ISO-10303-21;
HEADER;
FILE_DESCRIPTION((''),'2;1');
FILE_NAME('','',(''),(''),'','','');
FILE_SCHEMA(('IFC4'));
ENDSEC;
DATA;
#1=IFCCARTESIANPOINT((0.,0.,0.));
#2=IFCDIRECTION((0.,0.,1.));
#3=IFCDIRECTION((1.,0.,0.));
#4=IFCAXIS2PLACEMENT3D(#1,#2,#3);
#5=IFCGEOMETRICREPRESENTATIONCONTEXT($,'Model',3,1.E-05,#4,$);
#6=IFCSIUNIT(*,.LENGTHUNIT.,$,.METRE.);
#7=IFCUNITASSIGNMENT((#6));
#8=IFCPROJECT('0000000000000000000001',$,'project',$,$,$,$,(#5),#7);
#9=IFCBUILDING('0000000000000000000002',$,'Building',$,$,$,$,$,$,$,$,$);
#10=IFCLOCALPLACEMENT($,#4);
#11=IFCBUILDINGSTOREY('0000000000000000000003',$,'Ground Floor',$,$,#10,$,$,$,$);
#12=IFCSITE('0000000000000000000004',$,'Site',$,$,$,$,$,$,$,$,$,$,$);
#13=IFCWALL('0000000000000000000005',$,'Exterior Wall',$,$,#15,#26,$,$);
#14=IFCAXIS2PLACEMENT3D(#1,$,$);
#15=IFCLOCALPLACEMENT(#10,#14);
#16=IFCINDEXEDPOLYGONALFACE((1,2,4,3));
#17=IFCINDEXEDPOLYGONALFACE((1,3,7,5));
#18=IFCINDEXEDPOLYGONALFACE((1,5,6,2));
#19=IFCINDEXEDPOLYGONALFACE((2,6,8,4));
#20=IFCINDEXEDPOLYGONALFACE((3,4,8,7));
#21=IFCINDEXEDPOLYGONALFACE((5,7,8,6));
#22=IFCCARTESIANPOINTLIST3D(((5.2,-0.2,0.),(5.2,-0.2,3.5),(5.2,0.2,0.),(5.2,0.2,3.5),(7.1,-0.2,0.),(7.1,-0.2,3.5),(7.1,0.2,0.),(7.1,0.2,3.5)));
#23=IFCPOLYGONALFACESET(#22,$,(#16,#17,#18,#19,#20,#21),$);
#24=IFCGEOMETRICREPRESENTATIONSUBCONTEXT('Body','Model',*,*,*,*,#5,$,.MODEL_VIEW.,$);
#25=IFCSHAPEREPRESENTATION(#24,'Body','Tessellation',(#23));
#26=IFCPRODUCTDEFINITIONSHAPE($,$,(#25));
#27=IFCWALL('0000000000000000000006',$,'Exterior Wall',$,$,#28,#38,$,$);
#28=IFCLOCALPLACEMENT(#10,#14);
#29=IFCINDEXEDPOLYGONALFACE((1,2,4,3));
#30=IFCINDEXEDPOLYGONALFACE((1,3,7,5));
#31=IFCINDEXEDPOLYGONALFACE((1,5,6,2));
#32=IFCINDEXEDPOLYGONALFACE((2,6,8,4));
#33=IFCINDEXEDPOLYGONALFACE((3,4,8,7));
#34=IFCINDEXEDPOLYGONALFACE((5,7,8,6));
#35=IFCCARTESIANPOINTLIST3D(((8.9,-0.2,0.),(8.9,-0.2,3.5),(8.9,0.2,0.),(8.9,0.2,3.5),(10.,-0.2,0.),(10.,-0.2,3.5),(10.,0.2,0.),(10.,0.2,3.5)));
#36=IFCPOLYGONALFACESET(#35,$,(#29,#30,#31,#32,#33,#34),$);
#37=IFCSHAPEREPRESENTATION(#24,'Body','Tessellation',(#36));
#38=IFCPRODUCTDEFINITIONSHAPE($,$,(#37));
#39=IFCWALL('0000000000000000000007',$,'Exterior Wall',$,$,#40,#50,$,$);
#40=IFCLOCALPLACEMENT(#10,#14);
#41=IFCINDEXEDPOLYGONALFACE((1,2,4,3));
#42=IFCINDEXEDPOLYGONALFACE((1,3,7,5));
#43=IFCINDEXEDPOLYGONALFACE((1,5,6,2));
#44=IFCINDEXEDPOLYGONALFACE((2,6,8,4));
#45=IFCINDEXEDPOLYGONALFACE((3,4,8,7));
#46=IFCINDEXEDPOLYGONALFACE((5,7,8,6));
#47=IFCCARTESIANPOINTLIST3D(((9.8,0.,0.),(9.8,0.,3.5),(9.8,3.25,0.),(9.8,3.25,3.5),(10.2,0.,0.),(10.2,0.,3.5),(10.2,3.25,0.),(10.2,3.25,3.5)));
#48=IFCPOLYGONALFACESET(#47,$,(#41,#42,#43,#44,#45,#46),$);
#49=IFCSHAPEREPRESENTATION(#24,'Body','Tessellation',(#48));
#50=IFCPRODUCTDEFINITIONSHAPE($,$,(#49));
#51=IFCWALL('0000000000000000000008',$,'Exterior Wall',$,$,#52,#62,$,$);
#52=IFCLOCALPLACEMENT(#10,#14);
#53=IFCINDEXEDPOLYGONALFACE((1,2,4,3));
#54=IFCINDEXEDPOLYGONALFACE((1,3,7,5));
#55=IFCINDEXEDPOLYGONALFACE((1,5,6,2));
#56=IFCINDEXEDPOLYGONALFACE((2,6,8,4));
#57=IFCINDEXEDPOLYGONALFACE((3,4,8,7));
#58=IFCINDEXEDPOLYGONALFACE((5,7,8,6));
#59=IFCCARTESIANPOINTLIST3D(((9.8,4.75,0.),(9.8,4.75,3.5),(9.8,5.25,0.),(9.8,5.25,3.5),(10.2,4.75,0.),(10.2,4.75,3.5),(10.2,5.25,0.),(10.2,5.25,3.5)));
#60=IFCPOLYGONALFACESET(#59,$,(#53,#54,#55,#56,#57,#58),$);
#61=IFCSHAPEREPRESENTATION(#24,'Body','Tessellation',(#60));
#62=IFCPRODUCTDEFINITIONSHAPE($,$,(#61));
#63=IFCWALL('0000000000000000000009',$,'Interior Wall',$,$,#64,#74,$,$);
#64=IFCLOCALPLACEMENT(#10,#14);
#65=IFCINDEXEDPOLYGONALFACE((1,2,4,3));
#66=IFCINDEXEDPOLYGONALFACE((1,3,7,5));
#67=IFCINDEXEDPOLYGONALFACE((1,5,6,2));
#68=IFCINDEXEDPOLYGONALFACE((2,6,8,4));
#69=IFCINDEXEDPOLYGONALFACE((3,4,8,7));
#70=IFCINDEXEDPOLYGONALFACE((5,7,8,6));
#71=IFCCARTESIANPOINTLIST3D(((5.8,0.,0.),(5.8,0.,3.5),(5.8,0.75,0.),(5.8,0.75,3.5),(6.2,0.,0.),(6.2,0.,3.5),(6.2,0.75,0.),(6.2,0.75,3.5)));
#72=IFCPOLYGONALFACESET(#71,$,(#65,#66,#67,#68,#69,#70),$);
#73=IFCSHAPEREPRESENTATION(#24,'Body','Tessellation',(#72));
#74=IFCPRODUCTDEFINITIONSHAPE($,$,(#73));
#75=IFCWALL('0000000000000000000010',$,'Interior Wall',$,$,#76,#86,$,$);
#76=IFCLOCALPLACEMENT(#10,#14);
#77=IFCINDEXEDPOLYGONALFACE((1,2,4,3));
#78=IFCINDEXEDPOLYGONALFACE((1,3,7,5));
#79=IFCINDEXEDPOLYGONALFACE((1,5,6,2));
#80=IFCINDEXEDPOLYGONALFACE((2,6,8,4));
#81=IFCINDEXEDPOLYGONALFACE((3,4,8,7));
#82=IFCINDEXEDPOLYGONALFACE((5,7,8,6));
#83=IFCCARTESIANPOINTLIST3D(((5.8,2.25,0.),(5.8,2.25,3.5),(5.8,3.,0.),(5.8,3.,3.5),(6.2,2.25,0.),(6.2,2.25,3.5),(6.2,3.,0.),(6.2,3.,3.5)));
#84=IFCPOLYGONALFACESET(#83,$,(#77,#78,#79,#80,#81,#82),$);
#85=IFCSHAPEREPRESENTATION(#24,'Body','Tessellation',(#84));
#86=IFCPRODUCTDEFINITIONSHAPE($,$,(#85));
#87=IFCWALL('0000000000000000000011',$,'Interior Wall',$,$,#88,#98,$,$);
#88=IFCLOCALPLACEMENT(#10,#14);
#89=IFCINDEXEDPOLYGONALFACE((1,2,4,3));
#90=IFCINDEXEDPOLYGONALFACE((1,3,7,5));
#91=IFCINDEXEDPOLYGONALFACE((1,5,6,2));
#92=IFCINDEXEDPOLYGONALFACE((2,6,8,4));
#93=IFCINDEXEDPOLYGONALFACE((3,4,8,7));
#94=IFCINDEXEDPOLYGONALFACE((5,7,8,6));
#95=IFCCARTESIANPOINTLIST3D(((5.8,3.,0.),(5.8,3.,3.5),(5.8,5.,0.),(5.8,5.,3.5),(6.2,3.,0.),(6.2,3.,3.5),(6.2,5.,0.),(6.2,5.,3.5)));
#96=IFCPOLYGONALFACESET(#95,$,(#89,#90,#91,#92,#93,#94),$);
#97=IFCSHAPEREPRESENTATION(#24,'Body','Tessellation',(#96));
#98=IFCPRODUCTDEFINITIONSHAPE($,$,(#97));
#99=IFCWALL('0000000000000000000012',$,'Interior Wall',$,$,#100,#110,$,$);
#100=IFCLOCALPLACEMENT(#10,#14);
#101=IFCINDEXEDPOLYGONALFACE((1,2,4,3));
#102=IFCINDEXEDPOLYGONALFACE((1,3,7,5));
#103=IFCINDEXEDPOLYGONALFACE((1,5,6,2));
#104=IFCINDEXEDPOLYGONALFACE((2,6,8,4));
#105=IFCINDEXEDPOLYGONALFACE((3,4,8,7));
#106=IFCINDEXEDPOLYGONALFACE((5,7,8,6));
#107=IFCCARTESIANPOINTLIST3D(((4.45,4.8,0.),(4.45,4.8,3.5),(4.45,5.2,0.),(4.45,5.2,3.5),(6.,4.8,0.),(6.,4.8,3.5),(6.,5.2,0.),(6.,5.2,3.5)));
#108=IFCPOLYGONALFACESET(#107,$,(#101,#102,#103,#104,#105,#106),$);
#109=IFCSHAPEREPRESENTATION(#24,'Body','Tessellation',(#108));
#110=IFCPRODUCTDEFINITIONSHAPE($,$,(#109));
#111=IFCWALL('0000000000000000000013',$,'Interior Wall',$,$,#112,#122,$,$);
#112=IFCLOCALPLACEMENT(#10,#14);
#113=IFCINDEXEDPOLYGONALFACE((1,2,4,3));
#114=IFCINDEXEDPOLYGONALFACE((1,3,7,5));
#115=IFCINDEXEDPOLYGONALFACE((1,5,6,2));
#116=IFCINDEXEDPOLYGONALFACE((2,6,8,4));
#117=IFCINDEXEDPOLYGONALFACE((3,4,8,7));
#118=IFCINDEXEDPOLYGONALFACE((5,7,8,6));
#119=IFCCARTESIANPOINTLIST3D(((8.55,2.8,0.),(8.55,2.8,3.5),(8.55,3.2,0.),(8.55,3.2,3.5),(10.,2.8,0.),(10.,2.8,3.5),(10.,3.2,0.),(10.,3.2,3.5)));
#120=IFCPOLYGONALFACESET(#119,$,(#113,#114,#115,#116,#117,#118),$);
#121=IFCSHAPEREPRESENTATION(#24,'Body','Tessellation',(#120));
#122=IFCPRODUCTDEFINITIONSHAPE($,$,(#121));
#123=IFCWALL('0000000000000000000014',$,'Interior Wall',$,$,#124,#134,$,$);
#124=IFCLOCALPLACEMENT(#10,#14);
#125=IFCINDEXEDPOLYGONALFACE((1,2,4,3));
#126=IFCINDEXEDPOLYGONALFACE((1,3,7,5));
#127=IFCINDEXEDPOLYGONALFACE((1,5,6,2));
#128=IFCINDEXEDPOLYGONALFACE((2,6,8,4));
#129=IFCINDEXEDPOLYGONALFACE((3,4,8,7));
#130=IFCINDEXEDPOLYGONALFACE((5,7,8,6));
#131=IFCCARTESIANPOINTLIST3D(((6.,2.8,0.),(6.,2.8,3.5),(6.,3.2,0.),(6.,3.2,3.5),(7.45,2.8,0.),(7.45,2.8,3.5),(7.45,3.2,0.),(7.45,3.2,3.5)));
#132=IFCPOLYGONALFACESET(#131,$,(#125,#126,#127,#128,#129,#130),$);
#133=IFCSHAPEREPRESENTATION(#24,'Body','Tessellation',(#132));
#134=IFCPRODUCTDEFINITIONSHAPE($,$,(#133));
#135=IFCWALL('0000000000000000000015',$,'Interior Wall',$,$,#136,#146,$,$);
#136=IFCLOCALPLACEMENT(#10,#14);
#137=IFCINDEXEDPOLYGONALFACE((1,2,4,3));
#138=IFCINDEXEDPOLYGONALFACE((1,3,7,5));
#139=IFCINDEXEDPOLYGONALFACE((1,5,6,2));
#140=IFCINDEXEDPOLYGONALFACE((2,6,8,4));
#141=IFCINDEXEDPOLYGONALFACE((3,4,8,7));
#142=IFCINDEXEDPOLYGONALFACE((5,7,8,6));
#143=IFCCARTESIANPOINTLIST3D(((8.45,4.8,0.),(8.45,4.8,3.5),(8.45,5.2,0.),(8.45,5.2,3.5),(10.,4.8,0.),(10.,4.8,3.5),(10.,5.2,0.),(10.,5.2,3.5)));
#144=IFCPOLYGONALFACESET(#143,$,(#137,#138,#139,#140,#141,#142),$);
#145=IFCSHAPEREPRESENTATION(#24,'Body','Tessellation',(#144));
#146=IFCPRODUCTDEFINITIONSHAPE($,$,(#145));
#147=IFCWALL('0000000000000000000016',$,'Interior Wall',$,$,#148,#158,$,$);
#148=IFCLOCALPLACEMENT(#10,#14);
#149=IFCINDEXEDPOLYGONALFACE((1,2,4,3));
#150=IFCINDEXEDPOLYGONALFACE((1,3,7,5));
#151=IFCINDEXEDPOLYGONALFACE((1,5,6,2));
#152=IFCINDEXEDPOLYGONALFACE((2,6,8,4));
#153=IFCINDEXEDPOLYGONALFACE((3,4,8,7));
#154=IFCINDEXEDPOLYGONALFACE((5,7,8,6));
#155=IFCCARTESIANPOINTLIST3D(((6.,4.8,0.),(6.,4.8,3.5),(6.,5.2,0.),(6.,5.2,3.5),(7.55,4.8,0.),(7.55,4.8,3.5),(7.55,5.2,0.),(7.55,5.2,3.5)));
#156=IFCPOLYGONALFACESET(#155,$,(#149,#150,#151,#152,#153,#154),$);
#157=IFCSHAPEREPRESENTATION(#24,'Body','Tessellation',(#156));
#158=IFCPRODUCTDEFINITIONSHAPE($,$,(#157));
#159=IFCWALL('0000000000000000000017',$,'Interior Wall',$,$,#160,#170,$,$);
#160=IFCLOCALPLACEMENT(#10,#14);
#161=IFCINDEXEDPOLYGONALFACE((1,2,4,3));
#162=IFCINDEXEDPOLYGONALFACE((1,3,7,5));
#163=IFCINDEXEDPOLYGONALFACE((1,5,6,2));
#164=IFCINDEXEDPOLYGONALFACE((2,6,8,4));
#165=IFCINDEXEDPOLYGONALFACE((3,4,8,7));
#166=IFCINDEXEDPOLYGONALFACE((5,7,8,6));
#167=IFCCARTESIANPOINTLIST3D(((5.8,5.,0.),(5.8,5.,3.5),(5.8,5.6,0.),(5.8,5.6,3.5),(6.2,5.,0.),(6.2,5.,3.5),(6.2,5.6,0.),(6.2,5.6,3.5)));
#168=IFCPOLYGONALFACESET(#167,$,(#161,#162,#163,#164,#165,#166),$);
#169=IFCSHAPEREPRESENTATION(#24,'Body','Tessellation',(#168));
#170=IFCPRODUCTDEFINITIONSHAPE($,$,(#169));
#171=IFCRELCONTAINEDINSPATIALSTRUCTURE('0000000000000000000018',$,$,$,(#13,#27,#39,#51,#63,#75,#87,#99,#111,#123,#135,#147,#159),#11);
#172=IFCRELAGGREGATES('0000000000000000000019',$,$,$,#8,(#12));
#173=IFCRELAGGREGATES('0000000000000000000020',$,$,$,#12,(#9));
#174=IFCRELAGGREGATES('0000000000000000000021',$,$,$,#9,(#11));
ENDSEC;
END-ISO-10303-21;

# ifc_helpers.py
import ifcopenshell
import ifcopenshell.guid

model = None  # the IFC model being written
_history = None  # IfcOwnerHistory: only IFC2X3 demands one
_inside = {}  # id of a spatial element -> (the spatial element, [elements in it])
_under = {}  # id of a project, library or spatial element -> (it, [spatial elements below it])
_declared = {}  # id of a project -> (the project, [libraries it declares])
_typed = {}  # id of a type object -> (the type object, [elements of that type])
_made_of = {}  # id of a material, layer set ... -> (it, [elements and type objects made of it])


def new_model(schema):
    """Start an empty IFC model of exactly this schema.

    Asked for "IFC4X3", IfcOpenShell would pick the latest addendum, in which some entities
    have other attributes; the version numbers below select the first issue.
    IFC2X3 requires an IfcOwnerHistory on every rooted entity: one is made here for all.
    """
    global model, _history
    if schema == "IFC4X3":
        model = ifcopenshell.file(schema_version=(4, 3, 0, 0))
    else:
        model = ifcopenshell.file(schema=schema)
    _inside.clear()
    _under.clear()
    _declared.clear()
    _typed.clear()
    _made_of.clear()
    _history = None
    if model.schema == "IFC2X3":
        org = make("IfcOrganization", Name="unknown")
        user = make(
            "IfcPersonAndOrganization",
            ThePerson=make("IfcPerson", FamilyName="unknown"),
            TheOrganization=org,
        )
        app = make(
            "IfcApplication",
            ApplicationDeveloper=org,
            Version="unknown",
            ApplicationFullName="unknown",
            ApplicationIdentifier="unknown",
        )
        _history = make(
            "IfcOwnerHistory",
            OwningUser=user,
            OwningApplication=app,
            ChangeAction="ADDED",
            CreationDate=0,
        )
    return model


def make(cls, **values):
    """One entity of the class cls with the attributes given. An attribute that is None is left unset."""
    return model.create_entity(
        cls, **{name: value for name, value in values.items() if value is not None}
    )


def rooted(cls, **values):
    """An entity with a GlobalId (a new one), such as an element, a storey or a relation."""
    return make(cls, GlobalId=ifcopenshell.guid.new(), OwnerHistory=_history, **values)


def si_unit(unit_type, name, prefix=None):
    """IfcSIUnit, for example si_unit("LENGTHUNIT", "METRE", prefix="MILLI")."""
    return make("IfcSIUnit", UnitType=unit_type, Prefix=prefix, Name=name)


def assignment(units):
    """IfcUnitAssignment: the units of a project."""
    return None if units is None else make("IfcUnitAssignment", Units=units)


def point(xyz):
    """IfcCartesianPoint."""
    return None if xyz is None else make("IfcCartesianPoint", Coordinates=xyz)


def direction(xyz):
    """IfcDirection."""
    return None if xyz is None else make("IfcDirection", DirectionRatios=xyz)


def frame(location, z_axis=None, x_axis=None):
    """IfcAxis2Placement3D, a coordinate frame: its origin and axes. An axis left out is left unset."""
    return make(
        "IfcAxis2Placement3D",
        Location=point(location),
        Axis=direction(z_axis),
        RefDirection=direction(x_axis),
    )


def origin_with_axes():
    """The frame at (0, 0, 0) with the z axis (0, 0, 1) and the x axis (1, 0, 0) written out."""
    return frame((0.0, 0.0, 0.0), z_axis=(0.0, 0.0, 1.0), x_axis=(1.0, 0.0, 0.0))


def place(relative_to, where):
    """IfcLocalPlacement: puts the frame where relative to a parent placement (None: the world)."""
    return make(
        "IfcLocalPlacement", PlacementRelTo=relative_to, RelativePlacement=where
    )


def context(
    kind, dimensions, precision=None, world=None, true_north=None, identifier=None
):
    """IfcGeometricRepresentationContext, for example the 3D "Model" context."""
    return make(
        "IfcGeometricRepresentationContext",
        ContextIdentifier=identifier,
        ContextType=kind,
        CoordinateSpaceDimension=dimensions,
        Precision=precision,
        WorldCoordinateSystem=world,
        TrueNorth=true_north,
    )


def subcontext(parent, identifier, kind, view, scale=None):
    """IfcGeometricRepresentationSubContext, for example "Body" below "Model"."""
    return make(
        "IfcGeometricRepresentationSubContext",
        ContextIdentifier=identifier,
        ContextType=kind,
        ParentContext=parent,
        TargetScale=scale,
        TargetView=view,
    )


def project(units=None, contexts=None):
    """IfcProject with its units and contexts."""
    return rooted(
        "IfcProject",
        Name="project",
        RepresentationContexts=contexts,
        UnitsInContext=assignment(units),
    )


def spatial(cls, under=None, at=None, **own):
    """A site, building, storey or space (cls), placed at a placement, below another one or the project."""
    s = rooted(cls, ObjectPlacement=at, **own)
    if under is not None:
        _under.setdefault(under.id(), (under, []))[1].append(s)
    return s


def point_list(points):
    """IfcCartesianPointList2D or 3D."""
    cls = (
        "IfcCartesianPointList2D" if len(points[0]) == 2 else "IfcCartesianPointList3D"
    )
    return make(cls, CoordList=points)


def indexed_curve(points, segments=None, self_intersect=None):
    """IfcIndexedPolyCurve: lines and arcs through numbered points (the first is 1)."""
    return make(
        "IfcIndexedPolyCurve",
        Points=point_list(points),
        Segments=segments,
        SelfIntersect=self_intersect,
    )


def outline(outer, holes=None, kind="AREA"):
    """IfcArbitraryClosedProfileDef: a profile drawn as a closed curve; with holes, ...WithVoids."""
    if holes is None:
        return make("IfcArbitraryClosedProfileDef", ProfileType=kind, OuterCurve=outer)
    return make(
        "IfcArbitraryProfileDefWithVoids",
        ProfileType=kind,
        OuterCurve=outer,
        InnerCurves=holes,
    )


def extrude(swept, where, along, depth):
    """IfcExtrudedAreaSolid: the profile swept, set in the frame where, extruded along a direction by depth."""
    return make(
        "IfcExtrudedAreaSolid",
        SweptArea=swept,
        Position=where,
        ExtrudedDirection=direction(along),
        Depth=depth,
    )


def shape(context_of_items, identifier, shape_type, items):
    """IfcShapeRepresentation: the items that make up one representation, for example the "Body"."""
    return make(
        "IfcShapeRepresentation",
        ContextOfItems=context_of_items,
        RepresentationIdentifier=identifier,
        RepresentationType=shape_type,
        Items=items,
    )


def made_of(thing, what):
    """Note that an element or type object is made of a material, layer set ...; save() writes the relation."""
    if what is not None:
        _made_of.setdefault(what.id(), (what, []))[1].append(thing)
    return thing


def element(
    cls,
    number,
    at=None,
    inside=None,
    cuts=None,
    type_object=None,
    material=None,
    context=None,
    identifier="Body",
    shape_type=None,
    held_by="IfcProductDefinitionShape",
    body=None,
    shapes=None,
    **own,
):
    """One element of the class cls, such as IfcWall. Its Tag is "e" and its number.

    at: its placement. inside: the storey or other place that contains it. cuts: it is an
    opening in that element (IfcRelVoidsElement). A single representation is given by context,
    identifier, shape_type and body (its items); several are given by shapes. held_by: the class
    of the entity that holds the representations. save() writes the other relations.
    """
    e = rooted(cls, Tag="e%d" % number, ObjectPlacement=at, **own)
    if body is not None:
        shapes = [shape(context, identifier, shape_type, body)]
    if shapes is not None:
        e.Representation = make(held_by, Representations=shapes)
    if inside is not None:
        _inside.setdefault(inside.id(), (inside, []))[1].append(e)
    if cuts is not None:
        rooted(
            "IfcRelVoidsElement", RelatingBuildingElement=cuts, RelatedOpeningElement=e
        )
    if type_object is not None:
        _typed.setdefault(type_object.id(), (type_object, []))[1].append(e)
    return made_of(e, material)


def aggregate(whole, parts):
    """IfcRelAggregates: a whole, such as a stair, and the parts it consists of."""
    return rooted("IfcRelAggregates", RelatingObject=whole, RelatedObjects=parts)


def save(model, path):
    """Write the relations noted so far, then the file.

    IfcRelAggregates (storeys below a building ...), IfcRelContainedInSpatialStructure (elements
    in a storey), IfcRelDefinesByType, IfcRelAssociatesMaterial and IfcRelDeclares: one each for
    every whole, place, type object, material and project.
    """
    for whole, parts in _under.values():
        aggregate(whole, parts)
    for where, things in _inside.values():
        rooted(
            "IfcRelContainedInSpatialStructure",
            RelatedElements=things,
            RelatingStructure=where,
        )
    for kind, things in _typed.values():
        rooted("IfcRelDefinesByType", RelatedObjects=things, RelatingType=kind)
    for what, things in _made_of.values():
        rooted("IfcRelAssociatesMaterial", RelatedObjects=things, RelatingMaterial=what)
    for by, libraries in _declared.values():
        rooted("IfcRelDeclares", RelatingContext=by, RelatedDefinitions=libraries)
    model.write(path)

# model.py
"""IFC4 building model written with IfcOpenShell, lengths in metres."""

from ifc_helpers import new_model, si_unit, frame, origin_with_axes, place, context, subcontext, project, spatial, indexed_curve, outline, extrude, element, save


model = new_model("IFC4")

# Units and contexts
model_context = context("Model", 3, precision=1e-05, world=origin_with_axes())
body_context = subcontext(model_context, "Body", "Model", "MODEL_VIEW")
ifc_project = project(units=[si_unit("LENGTHUNIT", "METRE")], contexts=[model_context])

# Site, building, storey
site = spatial("IfcSite", under=ifc_project, Name="Site")
building = spatial("IfcBuilding", under=site, Name="Building")
storey_placement = place(None, origin_with_axes())
storey = spatial("IfcBuildingStorey", under=building, at=storey_placement, Name="Ground Floor")

# Walls
wall_1_placement = place(storey_placement, frame((5.2, 0.0, 0.0), z_axis=(0.0, 0.0, 1.0), x_axis=(1.0, 0.0, 0.0)))
element("IfcWall", 1, at=wall_1_placement, inside=storey, Name="Exterior Wall", context=body_context, shape_type="SweptSolid", body=[
    extrude(outline(indexed_curve([(0.0, 0.0), (0.0, 0.4), (1.9, 0.4), (1.9, 0.0), (0.0, 0.0)], self_intersect=False)), frame((0.0, -0.2, 0.0), z_axis=(0.0, 0.0, 1.0), x_axis=(1.0, 0.0, 0.0)), (0.0, 0.0, 1.0), 3.5),
])
wall_2_placement = place(storey_placement, frame((8.9, 0.0, 0.0), z_axis=(0.0, 0.0, 1.0), x_axis=(1.0, 0.0, 0.0)))
element("IfcWall", 2, at=wall_2_placement, inside=storey, Name="Exterior Wall", context=body_context, shape_type="SweptSolid", body=[
    extrude(outline(indexed_curve([(0.0, 0.0), (0.0, 0.4), (1.1, 0.4), (1.1, 0.0), (0.0, 0.0)], self_intersect=False)), frame((0.0, -0.2, 0.0), z_axis=(0.0, 0.0, 1.0), x_axis=(1.0, 0.0, 0.0)), (0.0, 0.0, 1.0), 3.5),
])
wall_3_placement = place(storey_placement, frame((10.0, 0.0, 0.0), z_axis=(0.0, 0.0, 1.0), x_axis=(0.0, 1.0, 0.0)))
element("IfcWall", 3, at=wall_3_placement, inside=storey, Name="Exterior Wall", context=body_context, shape_type="SweptSolid", body=[
    extrude(outline(indexed_curve([(0.0, 0.0), (0.0, 0.4), (3.25, 0.4), (3.25, 0.0), (0.0, 0.0)], self_intersect=False)), frame((0.0, -0.2, 0.0), z_axis=(0.0, 0.0, 1.0), x_axis=(1.0, 0.0, 0.0)), (0.0, 0.0, 1.0), 3.5),
])
wall_4_placement = place(storey_placement, frame((10.0, 4.75, 0.0), z_axis=(0.0, 0.0, 1.0), x_axis=(0.0, 1.0, 0.0)))
element("IfcWall", 4, at=wall_4_placement, inside=storey, Name="Exterior Wall", context=body_context, shape_type="SweptSolid", body=[
    extrude(outline(indexed_curve([(0.0, 0.0), (0.0, 0.4), (0.5, 0.4), (0.5, 0.0), (0.0, 0.0)], self_intersect=False)), frame((0.0, -0.2, 0.0), z_axis=(0.0, 0.0, 1.0), x_axis=(1.0, 0.0, 0.0)), (0.0, 0.0, 1.0), 3.5),
])
for number, where, z_axis, x_axis, name in (
    (5, (6.0, 0.0, 0.0), (0.0, 0.0, 1.0), (0.0, 1.0, 0.0), "Interior Wall"),
    (6, (6.0, 2.25, 0.0), (0.0, 0.0, 1.0), (0.0, 1.0, 0.0), "Interior Wall"),
):
    element("IfcWall", number, at=place(storey_placement, frame(where, z_axis=z_axis, x_axis=x_axis)), inside=storey, Name=name, context=body_context, shape_type="SweptSolid", body=[
        extrude(outline(indexed_curve([(0.0, 0.0), (0.0, 0.4), (0.75, 0.4), (0.75, 0.0), (0.0, 0.0)], self_intersect=False)), frame((0.0, -0.2, 0.0), z_axis=(0.0, 0.0, 1.0), x_axis=(1.0, 0.0, 0.0)), (0.0, 0.0, 1.0), 3.5),
    ])
wall_5_placement = place(storey_placement, frame((6.0, 3.0, 0.0), z_axis=(0.0, 0.0, 1.0), x_axis=(0.0, 1.0, 0.0)))
element("IfcWall", 7, at=wall_5_placement, inside=storey, Name="Interior Wall", context=body_context, shape_type="SweptSolid", body=[
    extrude(outline(indexed_curve([(0.0, 0.0), (0.0, 0.4), (2.0, 0.4), (2.0, 0.0), (0.0, 0.0)], self_intersect=False)), frame((0.0, -0.2, 0.0), z_axis=(0.0, 0.0, 1.0), x_axis=(1.0, 0.0, 0.0)), (0.0, 0.0, 1.0), 3.5),
])
wall_6_placement = place(storey_placement, frame((6.0, 5.0, 0.0), z_axis=(0.0, 0.0, 1.0), x_axis=(-1.0, 0.0, 0.0)))
element("IfcWall", 8, at=wall_6_placement, inside=storey, Name="Interior Wall", context=body_context, shape_type="SweptSolid", body=[
    extrude(outline(indexed_curve([(0.0, 0.0), (0.0, 0.4), (1.55, 0.4), (1.55, 0.0), (0.0, 0.0)], self_intersect=False)), frame((0.0, -0.2, 0.0), z_axis=(0.0, 0.0, 1.0), x_axis=(1.0, 0.0, 0.0)), (0.0, 0.0, 1.0), 3.5),
])
wall_7_placement = place(storey_placement, frame((10.0, 3.0, 0.0), z_axis=(0.0, 0.0, 1.0), x_axis=(-1.0, 0.0, 0.0)))
element("IfcWall", 9, at=wall_7_placement, inside=storey, Name="Interior Wall", context=body_context, shape_type="SweptSolid", body=[
    extrude(outline(indexed_curve([(0.0, 0.0), (0.0, 0.4), (1.45, 0.4), (1.45, 0.0), (0.0, 0.0)], self_intersect=False)), frame((0.0, -0.2, 0.0), z_axis=(0.0, 0.0, 1.0), x_axis=(1.0, 0.0, 0.0)), (0.0, 0.0, 1.0), 3.5),
])
wall_8_placement = place(storey_placement, frame((7.45, 3.0, 0.0), z_axis=(0.0, 0.0, 1.0), x_axis=(-1.0, 0.0, 0.0)))
element("IfcWall", 10, at=wall_8_placement, inside=storey, Name="Interior Wall", context=body_context, shape_type="SweptSolid", body=[
    extrude(outline(indexed_curve([(0.0, 0.0), (0.0, 0.4), (1.45, 0.4), (1.45, 0.0), (0.0, 0.0)], self_intersect=False)), frame((0.0, -0.2, 0.0), z_axis=(0.0, 0.0, 1.0), x_axis=(1.0, 0.0, 0.0)), (0.0, 0.0, 1.0), 3.5),
])
wall_9_placement = place(storey_placement, frame((10.0, 5.0, 0.0), z_axis=(0.0, 0.0, 1.0), x_axis=(-1.0, 0.0, 0.0)))
element("IfcWall", 11, at=wall_9_placement, inside=storey, Name="Interior Wall", context=body_context, shape_type="SweptSolid", body=[
    extrude(outline(indexed_curve([(0.0, 0.0), (0.0, 0.4), (1.55, 0.4), (1.55, 0.0), (0.0, 0.0)], self_intersect=False)), frame((0.0, -0.2, 0.0), z_axis=(0.0, 0.0, 1.0), x_axis=(1.0, 0.0, 0.0)), (0.0, 0.0, 1.0), 3.5),
])
wall_10_placement = place(storey_placement, frame((7.55, 5.0, 0.0), z_axis=(0.0, 0.0, 1.0), x_axis=(-1.0, 0.0, 0.0)))
element("IfcWall", 12, at=wall_10_placement, inside=storey, Name="Interior Wall", context=body_context, shape_type="SweptSolid", body=[
    extrude(outline(indexed_curve([(0.0, 0.0), (0.0, 0.4), (1.55, 0.4), (1.55, 0.0), (0.0, 0.0)], self_intersect=False)), frame((0.0, -0.2, 0.0), z_axis=(0.0, 0.0, 1.0), x_axis=(1.0, 0.0, 0.0)), (0.0, 0.0, 1.0), 3.5),
])
wall_11_placement = place(storey_placement, frame((6.0, 5.0, 0.0), z_axis=(0.0, 0.0, 1.0), x_axis=(0.0, 1.0, 0.0)))
element("IfcWall", 13, at=wall_11_placement, inside=storey, Name="Interior Wall", context=body_context, shape_type="SweptSolid", body=[
    extrude(outline(indexed_curve([(0.0, 0.0), (0.0, 0.4), (0.6, 0.4), (0.6, 0.0), (0.0, 0.0)], self_intersect=False)), frame((0.0, -0.2, 0.0), z_axis=(0.0, 0.0, 1.0), x_axis=(1.0, 0.0, 0.0)), (0.0, 0.0, 1.0), 3.5),
])

save(model, "model.ifc")
